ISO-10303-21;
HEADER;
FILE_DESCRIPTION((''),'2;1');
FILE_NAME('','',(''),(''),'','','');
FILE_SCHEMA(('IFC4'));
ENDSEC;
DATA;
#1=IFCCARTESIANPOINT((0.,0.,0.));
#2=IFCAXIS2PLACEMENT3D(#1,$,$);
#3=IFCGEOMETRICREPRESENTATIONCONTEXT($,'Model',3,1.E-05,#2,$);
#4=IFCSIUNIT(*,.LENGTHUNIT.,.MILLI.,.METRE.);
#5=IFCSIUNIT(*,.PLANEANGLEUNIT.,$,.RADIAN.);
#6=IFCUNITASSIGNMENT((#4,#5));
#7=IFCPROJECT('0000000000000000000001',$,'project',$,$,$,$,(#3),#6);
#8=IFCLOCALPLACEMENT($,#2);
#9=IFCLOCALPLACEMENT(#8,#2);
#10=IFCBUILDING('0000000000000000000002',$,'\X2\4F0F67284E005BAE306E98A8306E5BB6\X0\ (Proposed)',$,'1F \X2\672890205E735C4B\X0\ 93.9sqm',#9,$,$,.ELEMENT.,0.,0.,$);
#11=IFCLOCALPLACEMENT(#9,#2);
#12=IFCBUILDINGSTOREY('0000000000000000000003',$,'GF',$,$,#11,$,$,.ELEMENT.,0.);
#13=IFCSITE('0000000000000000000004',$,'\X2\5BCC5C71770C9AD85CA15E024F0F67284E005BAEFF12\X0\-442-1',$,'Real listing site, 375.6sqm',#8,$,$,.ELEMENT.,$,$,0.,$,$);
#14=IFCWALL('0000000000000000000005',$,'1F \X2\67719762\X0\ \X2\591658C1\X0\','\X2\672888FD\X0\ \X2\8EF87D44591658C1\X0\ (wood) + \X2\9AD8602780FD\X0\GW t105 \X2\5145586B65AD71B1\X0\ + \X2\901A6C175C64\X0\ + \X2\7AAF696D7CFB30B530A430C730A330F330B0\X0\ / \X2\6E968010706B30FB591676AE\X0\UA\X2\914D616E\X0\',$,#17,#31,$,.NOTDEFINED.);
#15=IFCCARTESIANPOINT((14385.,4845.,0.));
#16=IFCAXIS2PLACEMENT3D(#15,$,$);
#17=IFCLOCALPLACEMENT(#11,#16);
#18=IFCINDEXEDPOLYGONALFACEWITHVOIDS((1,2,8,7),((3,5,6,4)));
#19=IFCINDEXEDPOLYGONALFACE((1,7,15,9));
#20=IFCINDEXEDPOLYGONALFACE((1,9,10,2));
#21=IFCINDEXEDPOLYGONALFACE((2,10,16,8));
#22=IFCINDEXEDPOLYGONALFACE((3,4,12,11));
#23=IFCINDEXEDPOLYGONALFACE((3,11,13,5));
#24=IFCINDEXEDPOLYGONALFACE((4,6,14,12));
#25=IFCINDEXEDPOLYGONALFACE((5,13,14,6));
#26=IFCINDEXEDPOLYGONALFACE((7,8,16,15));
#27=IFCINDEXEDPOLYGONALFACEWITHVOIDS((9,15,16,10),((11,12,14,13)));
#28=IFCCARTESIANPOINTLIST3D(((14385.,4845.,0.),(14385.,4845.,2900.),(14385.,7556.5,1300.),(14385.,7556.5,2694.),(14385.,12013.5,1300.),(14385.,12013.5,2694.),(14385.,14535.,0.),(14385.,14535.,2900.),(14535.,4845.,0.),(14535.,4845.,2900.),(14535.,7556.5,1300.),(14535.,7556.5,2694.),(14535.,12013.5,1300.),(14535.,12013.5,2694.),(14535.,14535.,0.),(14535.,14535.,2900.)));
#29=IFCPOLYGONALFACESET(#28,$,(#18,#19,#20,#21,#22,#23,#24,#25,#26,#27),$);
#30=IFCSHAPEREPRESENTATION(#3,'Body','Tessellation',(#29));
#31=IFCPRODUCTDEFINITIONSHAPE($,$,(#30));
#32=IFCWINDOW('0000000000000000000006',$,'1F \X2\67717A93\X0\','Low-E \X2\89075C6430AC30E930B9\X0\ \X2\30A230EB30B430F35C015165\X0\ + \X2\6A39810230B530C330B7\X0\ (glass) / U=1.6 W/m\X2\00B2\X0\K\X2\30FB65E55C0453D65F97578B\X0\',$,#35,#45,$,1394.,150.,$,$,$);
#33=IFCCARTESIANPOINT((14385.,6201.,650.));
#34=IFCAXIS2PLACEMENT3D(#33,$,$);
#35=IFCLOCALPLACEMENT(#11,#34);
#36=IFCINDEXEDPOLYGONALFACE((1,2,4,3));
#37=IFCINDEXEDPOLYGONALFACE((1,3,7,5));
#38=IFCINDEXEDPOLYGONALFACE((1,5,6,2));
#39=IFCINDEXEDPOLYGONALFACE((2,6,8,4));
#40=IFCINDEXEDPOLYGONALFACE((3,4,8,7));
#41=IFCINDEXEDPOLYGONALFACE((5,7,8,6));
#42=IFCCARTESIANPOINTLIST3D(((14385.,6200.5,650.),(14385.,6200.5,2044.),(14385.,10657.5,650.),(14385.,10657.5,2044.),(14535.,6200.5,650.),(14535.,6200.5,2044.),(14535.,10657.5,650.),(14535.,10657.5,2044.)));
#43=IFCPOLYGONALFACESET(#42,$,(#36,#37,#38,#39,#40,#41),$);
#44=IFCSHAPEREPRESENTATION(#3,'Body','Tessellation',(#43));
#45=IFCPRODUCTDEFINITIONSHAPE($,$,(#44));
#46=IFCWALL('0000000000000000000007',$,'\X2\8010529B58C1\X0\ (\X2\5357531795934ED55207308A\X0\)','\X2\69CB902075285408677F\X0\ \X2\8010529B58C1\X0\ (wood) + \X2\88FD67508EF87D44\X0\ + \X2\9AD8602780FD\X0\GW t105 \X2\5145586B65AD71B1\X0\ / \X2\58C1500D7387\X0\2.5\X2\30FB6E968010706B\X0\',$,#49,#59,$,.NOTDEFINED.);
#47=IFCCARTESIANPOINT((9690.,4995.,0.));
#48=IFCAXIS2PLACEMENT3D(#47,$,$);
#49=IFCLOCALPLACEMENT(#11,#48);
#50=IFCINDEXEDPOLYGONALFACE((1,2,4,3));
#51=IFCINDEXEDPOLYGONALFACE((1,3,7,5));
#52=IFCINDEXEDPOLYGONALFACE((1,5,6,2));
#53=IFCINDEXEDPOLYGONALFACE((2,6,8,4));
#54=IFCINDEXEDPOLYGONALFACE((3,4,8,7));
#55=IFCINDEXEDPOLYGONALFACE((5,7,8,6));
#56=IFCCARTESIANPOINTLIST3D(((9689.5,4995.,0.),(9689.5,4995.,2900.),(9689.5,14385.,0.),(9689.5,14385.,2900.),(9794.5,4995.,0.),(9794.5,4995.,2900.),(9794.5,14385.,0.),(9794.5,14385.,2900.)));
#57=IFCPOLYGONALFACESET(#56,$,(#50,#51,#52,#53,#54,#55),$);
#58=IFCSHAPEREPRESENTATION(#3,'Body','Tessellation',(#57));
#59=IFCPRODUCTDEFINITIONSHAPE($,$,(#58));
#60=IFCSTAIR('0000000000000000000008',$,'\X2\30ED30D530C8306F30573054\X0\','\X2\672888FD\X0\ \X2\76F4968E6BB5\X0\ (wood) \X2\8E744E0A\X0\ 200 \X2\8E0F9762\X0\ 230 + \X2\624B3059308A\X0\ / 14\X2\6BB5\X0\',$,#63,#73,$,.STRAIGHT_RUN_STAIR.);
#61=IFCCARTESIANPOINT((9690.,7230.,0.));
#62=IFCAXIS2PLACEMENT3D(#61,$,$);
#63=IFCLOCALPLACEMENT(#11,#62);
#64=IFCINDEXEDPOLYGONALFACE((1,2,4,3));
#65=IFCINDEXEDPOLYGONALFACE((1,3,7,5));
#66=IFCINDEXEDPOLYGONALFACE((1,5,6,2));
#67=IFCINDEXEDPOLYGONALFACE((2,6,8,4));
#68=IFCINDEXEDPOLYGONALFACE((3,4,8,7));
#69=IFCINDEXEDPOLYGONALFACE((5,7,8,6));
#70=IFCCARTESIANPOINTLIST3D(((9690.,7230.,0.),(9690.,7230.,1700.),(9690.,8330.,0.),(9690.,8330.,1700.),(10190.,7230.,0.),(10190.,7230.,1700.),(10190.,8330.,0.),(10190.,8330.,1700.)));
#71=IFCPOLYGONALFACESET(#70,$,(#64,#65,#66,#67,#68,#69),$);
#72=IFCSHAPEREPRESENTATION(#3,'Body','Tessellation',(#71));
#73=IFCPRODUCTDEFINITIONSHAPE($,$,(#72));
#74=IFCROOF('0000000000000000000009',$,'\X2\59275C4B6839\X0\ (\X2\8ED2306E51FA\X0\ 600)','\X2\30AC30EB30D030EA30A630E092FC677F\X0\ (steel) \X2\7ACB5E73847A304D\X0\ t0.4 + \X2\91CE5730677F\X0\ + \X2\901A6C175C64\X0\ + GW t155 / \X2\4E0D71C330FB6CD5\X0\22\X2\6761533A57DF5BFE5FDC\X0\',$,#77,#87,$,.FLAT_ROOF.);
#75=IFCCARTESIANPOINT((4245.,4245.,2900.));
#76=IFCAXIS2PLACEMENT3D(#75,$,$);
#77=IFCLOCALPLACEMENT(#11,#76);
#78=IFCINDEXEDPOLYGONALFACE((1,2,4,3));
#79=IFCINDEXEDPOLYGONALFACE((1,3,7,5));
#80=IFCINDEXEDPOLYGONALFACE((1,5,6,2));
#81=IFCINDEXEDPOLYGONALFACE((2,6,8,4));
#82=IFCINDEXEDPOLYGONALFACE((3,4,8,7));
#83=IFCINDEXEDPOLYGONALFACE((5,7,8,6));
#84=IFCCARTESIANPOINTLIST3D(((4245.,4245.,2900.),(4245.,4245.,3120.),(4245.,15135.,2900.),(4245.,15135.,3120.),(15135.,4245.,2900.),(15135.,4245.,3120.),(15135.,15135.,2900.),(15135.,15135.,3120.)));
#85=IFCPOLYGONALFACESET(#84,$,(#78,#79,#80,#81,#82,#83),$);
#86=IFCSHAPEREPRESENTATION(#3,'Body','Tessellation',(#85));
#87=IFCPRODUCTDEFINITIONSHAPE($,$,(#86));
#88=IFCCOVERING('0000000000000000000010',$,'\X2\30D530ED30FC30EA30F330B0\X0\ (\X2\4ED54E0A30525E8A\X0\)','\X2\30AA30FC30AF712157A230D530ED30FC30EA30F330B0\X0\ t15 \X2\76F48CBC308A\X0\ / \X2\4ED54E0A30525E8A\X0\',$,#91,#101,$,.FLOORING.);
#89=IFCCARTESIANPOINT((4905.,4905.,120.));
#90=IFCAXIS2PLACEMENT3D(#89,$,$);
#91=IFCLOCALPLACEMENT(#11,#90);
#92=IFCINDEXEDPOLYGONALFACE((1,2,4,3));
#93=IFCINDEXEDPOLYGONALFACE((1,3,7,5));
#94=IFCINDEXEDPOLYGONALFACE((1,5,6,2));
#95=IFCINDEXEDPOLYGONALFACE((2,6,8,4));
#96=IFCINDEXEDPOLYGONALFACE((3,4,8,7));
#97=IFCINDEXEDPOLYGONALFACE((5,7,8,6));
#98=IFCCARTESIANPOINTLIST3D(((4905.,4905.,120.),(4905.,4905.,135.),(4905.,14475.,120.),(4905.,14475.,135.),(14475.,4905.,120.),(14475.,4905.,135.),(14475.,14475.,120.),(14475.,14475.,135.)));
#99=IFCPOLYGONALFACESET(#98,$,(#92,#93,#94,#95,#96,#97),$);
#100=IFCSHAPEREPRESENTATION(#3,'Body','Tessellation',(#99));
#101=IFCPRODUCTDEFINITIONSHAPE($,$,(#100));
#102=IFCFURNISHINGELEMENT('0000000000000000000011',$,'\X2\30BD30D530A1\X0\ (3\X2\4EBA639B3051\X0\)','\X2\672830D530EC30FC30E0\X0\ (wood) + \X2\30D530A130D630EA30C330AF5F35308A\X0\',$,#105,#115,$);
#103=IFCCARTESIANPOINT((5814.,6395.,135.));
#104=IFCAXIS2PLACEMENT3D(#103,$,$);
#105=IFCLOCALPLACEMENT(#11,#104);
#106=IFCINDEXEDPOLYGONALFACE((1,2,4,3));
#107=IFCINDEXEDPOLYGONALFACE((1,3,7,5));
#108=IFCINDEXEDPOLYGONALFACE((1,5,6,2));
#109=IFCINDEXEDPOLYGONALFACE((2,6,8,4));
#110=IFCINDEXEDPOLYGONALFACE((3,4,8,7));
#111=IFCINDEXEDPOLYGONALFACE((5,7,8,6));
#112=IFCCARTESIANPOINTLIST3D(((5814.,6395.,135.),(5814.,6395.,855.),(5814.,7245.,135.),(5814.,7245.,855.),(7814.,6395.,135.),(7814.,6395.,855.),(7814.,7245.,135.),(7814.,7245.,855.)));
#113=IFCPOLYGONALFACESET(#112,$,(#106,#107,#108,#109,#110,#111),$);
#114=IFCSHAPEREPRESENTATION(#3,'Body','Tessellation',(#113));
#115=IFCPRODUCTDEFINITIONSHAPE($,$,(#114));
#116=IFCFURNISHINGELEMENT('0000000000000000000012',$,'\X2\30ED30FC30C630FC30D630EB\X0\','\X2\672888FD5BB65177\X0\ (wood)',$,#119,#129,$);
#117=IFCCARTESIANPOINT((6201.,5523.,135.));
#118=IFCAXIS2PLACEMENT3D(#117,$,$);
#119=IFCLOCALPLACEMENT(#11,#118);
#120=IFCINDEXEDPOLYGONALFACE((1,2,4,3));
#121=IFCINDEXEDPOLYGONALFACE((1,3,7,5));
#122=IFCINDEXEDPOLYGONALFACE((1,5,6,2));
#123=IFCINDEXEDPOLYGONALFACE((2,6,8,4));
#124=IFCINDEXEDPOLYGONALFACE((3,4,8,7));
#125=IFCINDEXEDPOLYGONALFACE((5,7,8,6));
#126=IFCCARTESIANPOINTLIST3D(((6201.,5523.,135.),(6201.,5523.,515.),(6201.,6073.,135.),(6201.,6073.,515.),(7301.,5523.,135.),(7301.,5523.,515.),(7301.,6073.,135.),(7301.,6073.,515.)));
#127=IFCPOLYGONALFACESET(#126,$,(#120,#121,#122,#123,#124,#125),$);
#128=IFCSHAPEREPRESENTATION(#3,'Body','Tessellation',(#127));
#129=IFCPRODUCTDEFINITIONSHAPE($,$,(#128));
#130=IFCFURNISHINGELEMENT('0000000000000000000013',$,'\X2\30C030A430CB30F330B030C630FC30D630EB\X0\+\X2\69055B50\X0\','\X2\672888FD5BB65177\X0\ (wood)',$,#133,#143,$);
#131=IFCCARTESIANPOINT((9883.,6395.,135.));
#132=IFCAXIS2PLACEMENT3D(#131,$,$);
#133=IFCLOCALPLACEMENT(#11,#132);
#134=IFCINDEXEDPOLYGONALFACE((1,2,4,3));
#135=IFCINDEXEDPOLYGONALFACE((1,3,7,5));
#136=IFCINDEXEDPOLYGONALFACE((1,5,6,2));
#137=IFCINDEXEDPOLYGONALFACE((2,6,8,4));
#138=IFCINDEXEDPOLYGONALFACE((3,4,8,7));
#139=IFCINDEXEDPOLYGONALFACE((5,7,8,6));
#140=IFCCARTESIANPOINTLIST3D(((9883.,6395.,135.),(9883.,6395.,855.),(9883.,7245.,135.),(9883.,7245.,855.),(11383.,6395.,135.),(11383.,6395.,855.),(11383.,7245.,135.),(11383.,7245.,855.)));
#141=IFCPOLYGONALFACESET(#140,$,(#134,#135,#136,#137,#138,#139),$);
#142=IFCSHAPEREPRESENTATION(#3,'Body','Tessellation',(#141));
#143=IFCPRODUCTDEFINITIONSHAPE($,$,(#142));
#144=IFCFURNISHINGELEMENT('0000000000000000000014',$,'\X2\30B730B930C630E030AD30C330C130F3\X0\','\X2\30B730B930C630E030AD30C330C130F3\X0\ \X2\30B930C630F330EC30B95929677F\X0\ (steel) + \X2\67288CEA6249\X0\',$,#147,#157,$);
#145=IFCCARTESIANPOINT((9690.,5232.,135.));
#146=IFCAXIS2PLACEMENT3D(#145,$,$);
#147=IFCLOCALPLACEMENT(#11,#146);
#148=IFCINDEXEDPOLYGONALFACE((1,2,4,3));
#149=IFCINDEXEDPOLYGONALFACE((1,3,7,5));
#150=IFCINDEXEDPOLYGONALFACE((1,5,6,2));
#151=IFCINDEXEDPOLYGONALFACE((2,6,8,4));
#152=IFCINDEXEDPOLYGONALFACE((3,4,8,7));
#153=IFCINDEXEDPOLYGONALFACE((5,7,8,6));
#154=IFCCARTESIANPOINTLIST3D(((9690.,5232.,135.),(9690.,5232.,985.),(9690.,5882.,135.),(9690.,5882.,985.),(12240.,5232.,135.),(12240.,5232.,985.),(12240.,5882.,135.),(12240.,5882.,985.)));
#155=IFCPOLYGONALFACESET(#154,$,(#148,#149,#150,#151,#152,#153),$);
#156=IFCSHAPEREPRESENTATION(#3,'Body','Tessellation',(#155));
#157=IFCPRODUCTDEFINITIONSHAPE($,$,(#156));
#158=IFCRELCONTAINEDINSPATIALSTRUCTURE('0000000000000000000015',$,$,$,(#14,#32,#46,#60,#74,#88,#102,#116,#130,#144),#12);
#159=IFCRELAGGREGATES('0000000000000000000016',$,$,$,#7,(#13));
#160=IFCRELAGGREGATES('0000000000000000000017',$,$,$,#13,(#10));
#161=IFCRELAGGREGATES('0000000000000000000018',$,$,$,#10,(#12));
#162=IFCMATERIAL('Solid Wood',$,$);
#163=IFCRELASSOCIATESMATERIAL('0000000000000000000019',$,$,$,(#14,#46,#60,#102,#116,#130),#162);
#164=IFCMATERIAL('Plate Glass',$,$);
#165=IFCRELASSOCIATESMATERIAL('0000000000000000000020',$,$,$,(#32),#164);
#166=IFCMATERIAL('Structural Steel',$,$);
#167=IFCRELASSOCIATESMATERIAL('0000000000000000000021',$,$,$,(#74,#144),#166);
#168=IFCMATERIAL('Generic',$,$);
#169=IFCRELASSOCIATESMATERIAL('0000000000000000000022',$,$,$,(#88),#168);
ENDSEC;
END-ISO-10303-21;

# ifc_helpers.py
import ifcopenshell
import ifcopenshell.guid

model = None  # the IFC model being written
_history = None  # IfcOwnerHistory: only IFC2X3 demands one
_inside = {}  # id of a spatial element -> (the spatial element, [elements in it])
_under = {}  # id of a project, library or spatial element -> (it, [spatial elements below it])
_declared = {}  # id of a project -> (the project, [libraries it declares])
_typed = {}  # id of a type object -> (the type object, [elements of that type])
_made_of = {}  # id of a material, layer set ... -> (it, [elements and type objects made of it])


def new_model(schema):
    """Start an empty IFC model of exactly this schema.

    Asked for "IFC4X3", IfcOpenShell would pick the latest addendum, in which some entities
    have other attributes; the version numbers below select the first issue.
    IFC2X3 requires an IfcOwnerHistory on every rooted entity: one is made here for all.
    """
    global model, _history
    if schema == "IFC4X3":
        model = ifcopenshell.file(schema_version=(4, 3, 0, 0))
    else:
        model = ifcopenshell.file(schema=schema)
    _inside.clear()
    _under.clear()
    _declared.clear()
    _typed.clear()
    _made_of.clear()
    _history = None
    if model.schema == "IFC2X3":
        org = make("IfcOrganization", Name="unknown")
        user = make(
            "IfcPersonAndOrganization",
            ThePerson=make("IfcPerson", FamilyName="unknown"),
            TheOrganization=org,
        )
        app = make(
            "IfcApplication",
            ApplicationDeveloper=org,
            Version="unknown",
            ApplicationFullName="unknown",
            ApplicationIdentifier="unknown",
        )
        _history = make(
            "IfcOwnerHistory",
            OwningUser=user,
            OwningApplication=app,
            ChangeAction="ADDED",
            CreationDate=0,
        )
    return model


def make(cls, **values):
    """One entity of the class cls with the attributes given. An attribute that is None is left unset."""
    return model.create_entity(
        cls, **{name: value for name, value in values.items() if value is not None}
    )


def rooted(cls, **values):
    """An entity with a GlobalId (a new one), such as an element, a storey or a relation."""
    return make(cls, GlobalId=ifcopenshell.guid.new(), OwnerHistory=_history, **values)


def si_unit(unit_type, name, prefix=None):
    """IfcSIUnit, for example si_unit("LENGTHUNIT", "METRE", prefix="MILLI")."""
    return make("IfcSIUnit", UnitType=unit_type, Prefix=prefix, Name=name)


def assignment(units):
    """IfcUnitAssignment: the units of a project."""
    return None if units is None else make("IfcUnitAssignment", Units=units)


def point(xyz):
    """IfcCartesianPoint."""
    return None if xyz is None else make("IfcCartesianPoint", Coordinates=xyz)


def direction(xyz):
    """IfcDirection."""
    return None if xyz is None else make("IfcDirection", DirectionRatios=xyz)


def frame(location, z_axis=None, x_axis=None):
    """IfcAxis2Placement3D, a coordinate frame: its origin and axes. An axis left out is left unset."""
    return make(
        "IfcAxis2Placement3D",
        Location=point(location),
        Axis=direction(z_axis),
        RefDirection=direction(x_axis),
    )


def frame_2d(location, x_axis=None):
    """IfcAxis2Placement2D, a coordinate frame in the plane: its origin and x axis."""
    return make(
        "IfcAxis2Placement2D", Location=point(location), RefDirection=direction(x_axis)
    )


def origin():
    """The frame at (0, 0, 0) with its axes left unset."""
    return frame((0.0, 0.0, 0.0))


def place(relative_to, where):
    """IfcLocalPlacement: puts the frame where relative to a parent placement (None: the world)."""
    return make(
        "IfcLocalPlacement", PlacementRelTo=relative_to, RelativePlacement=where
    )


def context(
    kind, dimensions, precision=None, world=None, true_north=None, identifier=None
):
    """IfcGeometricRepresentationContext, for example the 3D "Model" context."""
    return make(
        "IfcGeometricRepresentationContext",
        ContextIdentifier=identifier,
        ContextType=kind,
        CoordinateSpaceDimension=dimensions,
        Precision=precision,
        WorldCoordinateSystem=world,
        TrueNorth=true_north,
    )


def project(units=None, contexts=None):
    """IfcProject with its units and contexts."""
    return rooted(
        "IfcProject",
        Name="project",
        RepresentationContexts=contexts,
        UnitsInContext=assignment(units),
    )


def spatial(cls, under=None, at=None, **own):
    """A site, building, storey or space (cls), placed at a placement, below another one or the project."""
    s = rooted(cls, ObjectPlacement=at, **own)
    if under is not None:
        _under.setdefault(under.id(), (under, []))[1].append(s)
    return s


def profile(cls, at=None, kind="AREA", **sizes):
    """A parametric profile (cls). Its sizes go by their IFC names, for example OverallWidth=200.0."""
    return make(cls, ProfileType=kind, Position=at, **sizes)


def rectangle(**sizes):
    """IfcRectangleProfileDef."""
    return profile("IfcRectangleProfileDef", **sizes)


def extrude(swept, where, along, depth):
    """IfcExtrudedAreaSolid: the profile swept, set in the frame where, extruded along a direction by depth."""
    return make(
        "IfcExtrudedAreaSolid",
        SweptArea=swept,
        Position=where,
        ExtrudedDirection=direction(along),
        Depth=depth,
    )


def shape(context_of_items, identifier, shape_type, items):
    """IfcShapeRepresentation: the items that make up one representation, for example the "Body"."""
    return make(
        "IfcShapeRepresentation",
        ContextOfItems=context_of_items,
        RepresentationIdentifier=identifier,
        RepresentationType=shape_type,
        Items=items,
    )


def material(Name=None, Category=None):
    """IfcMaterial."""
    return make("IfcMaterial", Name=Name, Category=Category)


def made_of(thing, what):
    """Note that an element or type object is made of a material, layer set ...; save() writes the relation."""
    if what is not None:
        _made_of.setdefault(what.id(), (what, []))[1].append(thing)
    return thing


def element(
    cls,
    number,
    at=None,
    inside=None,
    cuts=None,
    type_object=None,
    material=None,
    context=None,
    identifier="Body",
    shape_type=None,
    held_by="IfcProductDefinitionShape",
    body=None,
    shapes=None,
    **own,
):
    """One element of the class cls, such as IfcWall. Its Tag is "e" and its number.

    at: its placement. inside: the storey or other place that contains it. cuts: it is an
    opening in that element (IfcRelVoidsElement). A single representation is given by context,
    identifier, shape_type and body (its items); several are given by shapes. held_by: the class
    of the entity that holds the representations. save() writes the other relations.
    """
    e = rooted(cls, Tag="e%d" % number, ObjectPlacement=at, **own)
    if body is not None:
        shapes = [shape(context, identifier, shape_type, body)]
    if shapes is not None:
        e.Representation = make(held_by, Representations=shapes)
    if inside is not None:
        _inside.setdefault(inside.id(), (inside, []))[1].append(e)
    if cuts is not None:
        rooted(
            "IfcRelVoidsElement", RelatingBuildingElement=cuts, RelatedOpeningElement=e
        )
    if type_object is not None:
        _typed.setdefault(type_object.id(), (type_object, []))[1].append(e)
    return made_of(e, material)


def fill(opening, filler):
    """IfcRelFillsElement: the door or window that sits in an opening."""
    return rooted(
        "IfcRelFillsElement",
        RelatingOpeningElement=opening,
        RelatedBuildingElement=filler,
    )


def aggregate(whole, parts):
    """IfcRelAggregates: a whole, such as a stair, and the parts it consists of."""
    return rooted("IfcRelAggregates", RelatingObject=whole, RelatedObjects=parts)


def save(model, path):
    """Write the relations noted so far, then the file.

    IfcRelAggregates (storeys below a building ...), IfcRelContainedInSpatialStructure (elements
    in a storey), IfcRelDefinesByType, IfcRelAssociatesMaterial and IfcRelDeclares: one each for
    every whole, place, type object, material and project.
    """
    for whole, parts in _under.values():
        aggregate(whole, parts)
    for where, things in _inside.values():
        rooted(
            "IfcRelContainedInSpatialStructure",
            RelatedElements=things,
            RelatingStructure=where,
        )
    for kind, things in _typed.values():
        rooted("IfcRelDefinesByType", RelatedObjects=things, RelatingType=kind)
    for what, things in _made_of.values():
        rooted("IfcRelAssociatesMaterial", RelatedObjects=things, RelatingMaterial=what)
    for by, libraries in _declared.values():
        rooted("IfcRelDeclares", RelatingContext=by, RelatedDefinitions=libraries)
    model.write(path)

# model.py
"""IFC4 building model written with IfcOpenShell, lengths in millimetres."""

from ifc_helpers import new_model, si_unit, frame, frame_2d, origin, place, context, project, spatial, rectangle, extrude, material, element, fill, save


model = new_model("IFC4")

# Units and contexts
model_context = context("Model", 3, precision=1e-05, world=origin())
ifc_project = project(units=[si_unit("LENGTHUNIT", "METRE", prefix="MILLI"), si_unit("PLANEANGLEUNIT", "RADIAN")], contexts=[model_context])

# Site, building, storey
site_placement = place(None, origin())
site = spatial("IfcSite", under=ifc_project, at=site_placement, Name="富山県高岡市伏木一宮２-442-1", ObjectType="Real listing site, 375.6sqm", CompositionType="ELEMENT", RefElevation=0.0)
building_placement = place(site_placement, origin())
building = spatial("IfcBuilding", under=site, at=building_placement, Name="伏木一宮の風の家 (Proposed)", ObjectType="1F 木造平屋 93.9sqm", CompositionType="ELEMENT", ElevationOfRefHeight=0.0, ElevationOfTerrain=0.0)
storey_placement = place(building_placement, origin())
storey = spatial("IfcBuildingStorey", under=building, at=storey_placement, Name="GF", CompositionType="ELEMENT", Elevation=0.0)

# Shared definitions
ifc_material_1 = material(Name="Solid Wood")

# Shared definitions
ifc_material_2 = material(Name="Plate Glass")

# Wall, opening, window
wall_1_placement = place(storey_placement, frame((14385.0, 4845.0, 0.0)))
wall_1 = element("IfcWall", 1, at=wall_1_placement, inside=storey, material=ifc_material_1, Name="1F 東面 外壁", Description="木製 軸組外壁 (wood) + 高性能GW t105 充填断熱 + 通気層 + 窯業系サイディング / 準耐火・外皮UA配慮", PredefinedType="NOTDEFINED", context=model_context, shape_type="SweptSolid", body=[
    extrude(rectangle(XDim=150.0, YDim=9690.0, at=frame_2d((75.0, 4845.0))), frame((14385.0, 4845.0, 0.0)), (0.0, 0.0, 1.0), 2900.0),
])
opening_1_placement = place(storey_placement, frame((14385.0, 6201.0, 650.0)))
opening_1 = element("IfcOpeningElement", 2, at=opening_1_placement, cuts=wall_1, PredefinedType="NOTDEFINED", context=model_context, shape_type="SweptSolid", body=[
    extrude(rectangle(XDim=150.0, YDim=4457.0, at=frame_2d((75.0, 2228.0))), frame((14385.0, 6201.0, 650.0)), (0.0, 0.0, 1.0), 1394.0),
])
window_1_placement = place(storey_placement, frame((14385.0, 6201.0, 650.0)))
window_1 = element("IfcWindow", 3, at=window_1_placement, inside=storey, material=ifc_material_2, Name="1F 東窓", Description="Low-E 複層ガラス アルゴン封入 + 樹脂サッシ (glass) / U=1.6 W/m²K・日射取得型", OverallHeight=1394.0, OverallWidth=150.0, context=model_context, shape_type="SweptSolid", body=[
    extrude(rectangle(XDim=150.0, YDim=4457.0, at=frame_2d((75.0, 2228.0))), frame((14385.0, 6201.0, 650.0)), (0.0, 0.0, 1.0), 1394.0),
])
fill(opening_1, window_1)

# Wall
wall_2_placement = place(storey_placement, frame((9690.0, 4995.0, 0.0)))
element("IfcWall", 4, at=wall_2_placement, inside=storey, material=ifc_material_1, Name="耐力壁 (南北間仕切り)", Description="構造用合板 耐力壁 (wood) + 製材軸組 + 高性能GW t105 充填断熱 / 壁倍率2.5・準耐火", PredefinedType="NOTDEFINED", context=model_context, shape_type="SweptSolid", body=[
    extrude(rectangle(XDim=105.0, YDim=9390.0, at=frame_2d((52.0, 4695.0))), frame((9690.0, 4995.0, 0.0)), (0.0, 0.0, 1.0), 2900.0),
])

# Stair
stair_placement = place(storey_placement, frame((9690.0, 7230.0, 0.0)))
element("IfcStair", 5, at=stair_placement, inside=storey, material=ifc_material_1, Name="ロフトはしご", Description="木製 直階段 (wood) 蹴上 200 踏面 230 + 手すり / 14段", PredefinedType="STRAIGHT_RUN_STAIR", context=model_context, shape_type="SweptSolid", body=[
    extrude(rectangle(XDim=500.0, YDim=1100.0, at=frame_2d((250.0, 550.0))), frame((9690.0, 7230.0, 0.0)), (0.0, 0.0, 1.0), 1700.0),
])

# Roof
ifc_material_3 = material(Name="Structural Steel")
roof_placement = place(storey_placement, frame((4245.0, 4245.0, 2900.0)))
element("IfcRoof", 6, at=roof_placement, inside=storey, material=ifc_material_3, Name="大屋根 (軒の出 600)", Description="ガルバリウム鋼板 (steel) 立平葺き t0.4 + 野地板 + 通気層 + GW t155 / 不燃・法22条区域対応", PredefinedType="FLAT_ROOF", context=model_context, shape_type="SweptSolid", body=[
    extrude(rectangle(XDim=10890.0, YDim=10890.0, at=frame_2d((5445.0, 5445.0))), frame((4245.0, 4245.0, 2900.0)), (0.0, 0.0, 1.0), 220.0),
])

# Covering
ifc_material_4 = material(Name="Generic")
covering_placement = place(storey_placement, frame((4905.0, 4905.0, 120.0)))
element("IfcCovering", 7, at=covering_placement, inside=storey, material=ifc_material_4, Name="フローリング (仕上げ床)", Description="オーク無垢フローリング t15 直貼り / 仕上げ床", PredefinedType="FLOORING", context=model_context, shape_type="SweptSolid", body=[
    extrude(rectangle(XDim=9570.0, YDim=9570.0, at=frame_2d((4785.0, 4785.0))), frame((4905.0, 4905.0, 120.0)), (0.0, 0.0, 1.0), 15.0),
])

# Furnishing elements
furnishing_1_placement = place(storey_placement, frame((5814.0, 6395.0, 135.0)))
element("IfcFurnishingElement", 8, at=furnishing_1_placement, inside=storey, material=ifc_material_1, Name="ソファ (3人掛け)", Description="木フレーム (wood) + ファブリック張り", context=model_context, shape_type="SweptSolid", body=[
    extrude(rectangle(XDim=2000.0, YDim=850.0, at=frame_2d((1000.0, 425.0))), frame((5814.0, 6395.0, 135.0)), (0.0, 0.0, 1.0), 720.0),
])
furnishing_2_placement = place(storey_placement, frame((6201.0, 5523.0, 135.0)))
element("IfcFurnishingElement", 9, at=furnishing_2_placement, inside=storey, material=ifc_material_1, Name="ローテーブル", Description="木製家具 (wood)", context=model_context, shape_type="SweptSolid", body=[
    extrude(rectangle(XDim=1100.0, YDim=550.0, at=frame_2d((550.0, 275.0))), frame((6201.0, 5523.0, 135.0)), (0.0, 0.0, 1.0), 380.0),
])
furnishing_3_placement = place(storey_placement, frame((9883.0, 6395.0, 135.0)))
element("IfcFurnishingElement", 10, at=furnishing_3_placement, inside=storey, material=ifc_material_1, Name="ダイニングテーブル+椅子", Description="木製家具 (wood)", context=model_context, shape_type="SweptSolid", body=[
    extrude(rectangle(XDim=1500.0, YDim=850.0, at=frame_2d((750.0, 425.0))), frame((9883.0, 6395.0, 135.0)), (0.0, 0.0, 1.0), 720.0),
])
furnishing_4_placement = place(storey_placement, frame((9690.0, 5232.0, 135.0)))
element("IfcFurnishingElement", 11, at=furnishing_4_placement, inside=storey, material=ifc_material_3, Name="システムキッチン", Description="システムキッチン ステンレス天板 (steel) + 木質扉", context=model_context, shape_type="SweptSolid", body=[
    extrude(rectangle(XDim=2550.0, YDim=650.0, at=frame_2d((1275.0, 325.0))), frame((9690.0, 5232.0, 135.0)), (0.0, 0.0, 1.0), 850.0),
])

save(model, "model.ifc")
